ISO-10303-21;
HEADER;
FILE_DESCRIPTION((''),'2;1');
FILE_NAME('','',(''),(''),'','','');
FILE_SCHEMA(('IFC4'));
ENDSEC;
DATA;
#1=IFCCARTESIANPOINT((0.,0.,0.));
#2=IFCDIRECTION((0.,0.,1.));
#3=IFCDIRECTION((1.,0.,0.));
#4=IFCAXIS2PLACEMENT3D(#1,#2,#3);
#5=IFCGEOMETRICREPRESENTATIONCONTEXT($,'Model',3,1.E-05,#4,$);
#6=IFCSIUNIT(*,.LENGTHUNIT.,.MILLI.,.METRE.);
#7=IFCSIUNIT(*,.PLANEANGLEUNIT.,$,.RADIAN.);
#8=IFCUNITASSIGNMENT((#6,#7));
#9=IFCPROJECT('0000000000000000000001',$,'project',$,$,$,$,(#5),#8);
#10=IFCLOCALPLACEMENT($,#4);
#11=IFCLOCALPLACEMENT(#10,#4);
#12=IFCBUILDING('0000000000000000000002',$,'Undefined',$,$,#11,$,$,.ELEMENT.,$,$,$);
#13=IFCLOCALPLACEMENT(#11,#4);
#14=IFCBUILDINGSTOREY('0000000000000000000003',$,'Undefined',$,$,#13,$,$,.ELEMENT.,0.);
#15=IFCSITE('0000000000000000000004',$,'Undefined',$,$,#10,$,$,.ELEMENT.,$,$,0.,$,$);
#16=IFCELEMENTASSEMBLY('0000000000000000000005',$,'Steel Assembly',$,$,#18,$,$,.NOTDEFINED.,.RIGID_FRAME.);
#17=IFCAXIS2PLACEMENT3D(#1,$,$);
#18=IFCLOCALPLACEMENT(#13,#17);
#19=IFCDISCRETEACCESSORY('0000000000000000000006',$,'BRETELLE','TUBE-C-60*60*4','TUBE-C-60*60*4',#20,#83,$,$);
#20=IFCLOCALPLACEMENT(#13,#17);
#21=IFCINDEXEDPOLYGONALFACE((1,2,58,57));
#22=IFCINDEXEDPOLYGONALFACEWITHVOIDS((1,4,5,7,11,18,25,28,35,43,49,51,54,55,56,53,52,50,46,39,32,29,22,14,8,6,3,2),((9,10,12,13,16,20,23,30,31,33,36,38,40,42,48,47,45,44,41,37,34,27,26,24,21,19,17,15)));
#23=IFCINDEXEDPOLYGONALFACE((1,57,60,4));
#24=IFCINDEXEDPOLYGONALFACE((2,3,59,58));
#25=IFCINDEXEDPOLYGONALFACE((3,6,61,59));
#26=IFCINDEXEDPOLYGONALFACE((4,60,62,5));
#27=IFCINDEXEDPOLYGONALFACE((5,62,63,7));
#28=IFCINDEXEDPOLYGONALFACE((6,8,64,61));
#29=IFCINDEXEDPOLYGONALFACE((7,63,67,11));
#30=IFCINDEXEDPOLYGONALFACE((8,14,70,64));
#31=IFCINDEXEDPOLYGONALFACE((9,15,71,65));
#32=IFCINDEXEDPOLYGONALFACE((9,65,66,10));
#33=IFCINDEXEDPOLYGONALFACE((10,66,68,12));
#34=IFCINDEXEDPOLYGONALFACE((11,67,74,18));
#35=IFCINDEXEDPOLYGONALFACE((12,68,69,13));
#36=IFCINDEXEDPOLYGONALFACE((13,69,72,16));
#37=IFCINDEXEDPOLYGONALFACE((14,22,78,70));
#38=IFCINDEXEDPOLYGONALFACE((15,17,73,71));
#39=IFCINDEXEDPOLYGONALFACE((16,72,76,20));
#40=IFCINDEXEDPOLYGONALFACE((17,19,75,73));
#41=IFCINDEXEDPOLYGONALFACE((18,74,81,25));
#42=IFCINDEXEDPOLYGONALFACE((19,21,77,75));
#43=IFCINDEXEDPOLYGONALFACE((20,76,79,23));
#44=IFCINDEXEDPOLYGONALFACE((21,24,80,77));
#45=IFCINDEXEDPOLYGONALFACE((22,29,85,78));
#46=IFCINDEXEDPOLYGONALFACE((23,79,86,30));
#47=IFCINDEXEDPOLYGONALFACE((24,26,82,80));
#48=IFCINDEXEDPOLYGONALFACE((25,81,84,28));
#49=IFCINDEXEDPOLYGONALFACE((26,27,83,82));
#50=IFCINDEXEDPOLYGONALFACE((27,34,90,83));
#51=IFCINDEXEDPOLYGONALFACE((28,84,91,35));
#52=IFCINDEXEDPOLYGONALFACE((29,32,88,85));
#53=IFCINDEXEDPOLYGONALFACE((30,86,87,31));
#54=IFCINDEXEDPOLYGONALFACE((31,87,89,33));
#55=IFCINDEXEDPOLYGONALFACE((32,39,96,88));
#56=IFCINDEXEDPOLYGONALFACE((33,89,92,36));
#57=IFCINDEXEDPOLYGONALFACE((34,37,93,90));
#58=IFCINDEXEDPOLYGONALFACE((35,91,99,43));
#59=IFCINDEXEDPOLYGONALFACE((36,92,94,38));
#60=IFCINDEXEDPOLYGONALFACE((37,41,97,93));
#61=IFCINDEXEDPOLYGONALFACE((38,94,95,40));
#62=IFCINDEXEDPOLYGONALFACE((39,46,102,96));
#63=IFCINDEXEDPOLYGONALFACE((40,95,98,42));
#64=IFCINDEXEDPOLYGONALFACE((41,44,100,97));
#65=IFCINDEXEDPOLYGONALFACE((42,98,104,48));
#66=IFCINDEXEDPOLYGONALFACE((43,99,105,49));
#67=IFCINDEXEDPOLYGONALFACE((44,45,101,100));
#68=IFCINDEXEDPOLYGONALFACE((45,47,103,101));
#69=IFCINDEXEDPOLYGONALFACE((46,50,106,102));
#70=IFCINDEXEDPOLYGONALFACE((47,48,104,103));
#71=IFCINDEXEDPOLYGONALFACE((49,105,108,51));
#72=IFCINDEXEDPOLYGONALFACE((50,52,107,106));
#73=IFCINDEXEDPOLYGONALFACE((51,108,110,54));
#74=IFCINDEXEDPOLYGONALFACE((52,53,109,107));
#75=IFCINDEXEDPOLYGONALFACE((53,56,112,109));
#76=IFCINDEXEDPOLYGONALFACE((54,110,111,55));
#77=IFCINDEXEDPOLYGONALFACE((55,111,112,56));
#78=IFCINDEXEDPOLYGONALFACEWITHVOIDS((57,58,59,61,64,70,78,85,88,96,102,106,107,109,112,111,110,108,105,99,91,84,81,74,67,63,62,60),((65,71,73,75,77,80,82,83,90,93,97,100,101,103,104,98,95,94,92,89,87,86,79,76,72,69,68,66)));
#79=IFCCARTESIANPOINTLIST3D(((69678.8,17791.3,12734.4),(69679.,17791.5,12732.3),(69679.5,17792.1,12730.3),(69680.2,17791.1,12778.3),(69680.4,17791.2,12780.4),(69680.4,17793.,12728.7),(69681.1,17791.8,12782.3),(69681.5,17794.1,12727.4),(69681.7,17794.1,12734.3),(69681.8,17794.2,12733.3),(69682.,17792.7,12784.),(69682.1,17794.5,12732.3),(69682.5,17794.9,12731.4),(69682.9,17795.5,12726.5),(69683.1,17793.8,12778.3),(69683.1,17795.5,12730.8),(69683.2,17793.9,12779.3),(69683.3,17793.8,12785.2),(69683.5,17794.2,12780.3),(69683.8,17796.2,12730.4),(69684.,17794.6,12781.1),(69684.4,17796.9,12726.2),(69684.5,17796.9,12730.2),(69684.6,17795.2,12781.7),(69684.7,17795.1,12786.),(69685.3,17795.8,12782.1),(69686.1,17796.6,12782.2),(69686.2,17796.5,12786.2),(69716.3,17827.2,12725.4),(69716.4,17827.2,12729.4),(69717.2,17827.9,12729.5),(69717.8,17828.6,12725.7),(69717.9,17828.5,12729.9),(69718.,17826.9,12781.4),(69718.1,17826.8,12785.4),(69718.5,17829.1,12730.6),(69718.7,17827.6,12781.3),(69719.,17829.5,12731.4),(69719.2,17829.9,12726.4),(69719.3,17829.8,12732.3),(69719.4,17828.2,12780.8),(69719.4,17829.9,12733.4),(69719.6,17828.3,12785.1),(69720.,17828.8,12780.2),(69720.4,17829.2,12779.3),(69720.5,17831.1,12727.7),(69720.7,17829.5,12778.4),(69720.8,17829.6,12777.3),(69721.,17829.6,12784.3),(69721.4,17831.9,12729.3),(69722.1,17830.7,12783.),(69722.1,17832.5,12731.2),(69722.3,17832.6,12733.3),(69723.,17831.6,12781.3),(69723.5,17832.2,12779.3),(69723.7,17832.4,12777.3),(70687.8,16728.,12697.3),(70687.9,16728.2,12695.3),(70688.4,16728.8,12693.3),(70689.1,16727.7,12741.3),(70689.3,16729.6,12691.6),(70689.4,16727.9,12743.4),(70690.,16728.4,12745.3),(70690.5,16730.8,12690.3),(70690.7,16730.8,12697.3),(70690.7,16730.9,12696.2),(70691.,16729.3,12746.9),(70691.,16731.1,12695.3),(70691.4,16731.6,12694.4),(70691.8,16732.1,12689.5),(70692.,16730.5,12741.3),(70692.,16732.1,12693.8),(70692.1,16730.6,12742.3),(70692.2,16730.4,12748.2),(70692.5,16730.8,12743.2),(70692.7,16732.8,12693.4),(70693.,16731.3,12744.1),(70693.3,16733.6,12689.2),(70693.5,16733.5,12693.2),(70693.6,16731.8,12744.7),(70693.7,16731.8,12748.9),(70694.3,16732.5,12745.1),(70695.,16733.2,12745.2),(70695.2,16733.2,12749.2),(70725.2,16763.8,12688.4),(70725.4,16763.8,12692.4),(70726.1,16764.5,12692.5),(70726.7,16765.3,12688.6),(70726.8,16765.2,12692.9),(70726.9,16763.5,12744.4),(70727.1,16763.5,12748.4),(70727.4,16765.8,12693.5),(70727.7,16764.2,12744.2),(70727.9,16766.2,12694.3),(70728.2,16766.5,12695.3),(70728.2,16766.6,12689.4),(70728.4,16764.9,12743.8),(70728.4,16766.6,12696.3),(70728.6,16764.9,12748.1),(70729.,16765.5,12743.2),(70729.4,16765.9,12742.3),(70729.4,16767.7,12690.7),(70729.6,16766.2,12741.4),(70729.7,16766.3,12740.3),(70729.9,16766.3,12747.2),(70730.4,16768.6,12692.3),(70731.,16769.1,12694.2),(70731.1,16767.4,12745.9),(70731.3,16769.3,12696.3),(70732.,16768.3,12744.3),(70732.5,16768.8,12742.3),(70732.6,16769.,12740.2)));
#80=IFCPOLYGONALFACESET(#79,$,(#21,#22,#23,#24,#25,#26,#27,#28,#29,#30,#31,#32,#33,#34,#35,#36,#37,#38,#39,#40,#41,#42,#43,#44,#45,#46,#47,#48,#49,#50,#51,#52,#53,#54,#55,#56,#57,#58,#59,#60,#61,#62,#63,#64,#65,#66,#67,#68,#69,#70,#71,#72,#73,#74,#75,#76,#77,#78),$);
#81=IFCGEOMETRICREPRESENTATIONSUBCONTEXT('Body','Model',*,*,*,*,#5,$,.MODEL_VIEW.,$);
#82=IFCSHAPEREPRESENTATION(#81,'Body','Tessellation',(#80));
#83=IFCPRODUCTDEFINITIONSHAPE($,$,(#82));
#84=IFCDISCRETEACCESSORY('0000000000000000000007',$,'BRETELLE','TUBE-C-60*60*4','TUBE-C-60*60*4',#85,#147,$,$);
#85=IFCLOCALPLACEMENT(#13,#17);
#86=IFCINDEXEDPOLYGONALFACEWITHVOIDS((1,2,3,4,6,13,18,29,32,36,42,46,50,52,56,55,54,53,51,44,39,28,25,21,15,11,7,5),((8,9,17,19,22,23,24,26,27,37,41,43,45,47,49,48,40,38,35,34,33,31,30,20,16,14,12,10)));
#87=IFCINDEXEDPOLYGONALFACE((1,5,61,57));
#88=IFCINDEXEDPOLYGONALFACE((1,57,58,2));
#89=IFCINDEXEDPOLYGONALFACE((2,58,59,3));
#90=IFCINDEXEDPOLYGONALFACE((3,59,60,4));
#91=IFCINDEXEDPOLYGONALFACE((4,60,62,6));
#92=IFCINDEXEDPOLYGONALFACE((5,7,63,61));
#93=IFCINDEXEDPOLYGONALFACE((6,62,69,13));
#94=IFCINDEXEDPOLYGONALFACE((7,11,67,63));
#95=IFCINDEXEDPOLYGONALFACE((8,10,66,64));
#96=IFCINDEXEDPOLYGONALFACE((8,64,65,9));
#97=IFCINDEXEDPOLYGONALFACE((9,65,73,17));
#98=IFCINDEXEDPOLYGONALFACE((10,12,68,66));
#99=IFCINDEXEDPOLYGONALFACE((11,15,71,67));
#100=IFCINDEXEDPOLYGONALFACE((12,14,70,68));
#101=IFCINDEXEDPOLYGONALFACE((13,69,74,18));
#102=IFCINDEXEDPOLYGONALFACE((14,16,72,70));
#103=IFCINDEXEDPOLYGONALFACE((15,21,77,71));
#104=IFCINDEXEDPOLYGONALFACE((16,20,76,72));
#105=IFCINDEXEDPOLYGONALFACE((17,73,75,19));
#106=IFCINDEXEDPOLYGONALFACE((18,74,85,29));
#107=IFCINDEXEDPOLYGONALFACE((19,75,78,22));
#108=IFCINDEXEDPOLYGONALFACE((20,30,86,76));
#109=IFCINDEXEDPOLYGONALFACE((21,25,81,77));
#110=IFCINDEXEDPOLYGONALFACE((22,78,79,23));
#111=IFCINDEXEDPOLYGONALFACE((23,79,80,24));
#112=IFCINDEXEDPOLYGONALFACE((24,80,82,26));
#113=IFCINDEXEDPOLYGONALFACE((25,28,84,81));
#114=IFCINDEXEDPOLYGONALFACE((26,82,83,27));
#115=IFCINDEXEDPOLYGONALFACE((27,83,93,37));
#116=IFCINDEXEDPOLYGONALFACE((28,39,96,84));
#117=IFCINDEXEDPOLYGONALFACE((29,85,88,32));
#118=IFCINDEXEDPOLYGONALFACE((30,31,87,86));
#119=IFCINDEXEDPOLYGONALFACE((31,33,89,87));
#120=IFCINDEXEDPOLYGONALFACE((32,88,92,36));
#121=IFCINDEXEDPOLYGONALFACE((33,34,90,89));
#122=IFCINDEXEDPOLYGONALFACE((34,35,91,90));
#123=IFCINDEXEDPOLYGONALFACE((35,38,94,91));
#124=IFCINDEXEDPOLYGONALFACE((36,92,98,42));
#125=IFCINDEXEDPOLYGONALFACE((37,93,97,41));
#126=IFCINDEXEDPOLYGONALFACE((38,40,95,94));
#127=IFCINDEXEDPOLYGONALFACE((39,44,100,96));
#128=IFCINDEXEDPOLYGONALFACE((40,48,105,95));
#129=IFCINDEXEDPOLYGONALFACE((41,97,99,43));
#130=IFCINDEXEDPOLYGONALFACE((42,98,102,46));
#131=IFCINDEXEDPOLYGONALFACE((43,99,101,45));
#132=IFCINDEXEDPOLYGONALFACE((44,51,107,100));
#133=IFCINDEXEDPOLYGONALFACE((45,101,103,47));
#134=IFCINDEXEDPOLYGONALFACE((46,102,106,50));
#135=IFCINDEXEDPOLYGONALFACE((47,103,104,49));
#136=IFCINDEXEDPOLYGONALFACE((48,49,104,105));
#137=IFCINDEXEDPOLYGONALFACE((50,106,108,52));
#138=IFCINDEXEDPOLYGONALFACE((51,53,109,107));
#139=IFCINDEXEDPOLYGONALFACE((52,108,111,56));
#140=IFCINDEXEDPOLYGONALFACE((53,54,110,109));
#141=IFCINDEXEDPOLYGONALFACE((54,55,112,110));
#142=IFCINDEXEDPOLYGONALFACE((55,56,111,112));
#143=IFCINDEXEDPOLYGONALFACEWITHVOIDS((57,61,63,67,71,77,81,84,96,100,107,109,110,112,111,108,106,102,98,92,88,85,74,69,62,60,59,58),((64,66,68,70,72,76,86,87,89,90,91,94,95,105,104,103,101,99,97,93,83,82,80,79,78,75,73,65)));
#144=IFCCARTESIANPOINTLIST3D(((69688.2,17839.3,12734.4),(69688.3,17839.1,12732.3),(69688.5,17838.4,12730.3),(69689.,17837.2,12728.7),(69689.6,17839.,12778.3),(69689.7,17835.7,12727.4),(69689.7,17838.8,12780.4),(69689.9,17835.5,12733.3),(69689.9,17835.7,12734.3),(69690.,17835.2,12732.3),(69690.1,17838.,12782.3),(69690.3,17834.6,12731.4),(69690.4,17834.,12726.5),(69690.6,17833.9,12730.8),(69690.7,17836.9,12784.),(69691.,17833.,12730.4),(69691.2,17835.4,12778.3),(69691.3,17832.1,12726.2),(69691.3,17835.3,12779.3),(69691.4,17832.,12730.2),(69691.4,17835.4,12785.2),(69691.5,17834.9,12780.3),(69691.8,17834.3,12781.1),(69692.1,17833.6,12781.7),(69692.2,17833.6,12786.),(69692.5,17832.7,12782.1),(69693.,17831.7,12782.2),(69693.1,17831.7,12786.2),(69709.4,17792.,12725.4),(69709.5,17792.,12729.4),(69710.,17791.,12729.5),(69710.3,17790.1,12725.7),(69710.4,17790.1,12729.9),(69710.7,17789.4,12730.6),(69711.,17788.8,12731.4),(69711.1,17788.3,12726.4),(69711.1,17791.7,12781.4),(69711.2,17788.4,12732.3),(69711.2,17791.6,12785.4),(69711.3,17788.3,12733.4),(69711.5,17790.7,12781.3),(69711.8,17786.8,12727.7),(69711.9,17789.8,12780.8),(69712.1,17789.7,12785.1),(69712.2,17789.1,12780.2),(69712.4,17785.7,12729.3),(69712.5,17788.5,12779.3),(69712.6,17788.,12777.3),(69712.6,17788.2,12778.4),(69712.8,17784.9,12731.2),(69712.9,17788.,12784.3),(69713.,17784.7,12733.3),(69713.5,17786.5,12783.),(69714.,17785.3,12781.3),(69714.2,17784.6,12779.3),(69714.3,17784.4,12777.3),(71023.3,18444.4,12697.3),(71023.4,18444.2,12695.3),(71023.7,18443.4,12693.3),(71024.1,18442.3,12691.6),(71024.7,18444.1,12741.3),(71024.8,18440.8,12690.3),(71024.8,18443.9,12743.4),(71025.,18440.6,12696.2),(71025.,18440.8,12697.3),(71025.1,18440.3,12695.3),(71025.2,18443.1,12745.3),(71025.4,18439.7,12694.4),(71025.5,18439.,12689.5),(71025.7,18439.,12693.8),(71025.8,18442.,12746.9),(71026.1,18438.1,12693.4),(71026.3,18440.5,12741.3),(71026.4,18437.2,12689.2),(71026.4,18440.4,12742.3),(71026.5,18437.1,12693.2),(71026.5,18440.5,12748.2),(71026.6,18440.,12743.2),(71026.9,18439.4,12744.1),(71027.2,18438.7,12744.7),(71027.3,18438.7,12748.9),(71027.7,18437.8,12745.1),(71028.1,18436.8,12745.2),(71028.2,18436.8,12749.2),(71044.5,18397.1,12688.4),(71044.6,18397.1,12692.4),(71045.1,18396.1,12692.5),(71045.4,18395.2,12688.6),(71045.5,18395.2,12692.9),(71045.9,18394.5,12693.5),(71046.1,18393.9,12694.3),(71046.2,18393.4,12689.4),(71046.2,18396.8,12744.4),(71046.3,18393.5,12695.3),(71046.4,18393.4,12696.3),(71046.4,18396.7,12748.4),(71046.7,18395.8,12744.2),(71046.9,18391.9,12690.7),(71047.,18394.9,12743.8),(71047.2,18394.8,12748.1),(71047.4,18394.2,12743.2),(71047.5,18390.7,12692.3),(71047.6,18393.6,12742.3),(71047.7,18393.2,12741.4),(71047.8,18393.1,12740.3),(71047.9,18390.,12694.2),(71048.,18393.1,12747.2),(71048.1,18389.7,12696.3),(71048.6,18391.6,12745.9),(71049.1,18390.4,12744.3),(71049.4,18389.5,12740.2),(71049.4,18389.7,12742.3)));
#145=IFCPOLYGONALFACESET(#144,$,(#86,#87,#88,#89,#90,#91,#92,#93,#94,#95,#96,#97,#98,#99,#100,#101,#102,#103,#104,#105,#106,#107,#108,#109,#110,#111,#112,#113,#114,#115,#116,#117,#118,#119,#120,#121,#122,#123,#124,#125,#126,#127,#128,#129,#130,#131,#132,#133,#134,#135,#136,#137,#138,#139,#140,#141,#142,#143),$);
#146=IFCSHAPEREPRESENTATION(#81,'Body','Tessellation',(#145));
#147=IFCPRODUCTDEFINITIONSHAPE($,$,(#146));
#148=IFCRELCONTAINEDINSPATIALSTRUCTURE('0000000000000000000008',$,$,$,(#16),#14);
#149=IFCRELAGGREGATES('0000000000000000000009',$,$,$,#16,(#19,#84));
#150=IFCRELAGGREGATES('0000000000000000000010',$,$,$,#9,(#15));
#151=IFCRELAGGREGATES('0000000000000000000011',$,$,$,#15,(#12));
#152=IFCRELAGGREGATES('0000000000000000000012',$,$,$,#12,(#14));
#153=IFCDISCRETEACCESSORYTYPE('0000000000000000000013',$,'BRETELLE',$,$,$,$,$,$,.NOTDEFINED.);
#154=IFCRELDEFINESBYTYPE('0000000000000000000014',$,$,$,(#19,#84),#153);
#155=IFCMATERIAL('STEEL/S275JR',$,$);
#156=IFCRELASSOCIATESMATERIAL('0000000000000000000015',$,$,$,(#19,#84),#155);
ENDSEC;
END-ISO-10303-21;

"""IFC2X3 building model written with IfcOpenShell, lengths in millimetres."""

from ifc_helpers import new_model, si_unit, frame, origin_with_axes, origin_2d_with_axis, place, context, subcontext, project, spatial, hollow_rectangle, extrude, material, type_object, element, aggregate, save


model = new_model("IFC2X3")

# Units and contexts
model_context = context("Model", 3, precision=1e-05, world=origin_with_axes())
body_context = subcontext(model_context, "Body", "Model", "MODEL_VIEW")
ifc_project = project(units=[si_unit("LENGTHUNIT", "METRE", prefix="MILLI"), si_unit("PLANEANGLEUNIT", "RADIAN")], contexts=[model_context])

# Site, building, storey
site_placement = place(None, origin_with_axes())
site = spatial("IfcSite", under=ifc_project, at=site_placement, Name="Undefined", CompositionType="ELEMENT", RefElevation=0.0)
building_placement = place(site_placement, origin_with_axes())
building = spatial("IfcBuilding", under=site, at=building_placement, Name="Undefined", CompositionType="ELEMENT")
storey_placement = place(building_placement, origin_with_axes())
storey = spatial("IfcBuildingStorey", under=building, at=storey_placement, Name="Undefined", CompositionType="ELEMENT", Elevation=0.0)

# Shared definitions
ifc_material = material(Name="STEEL/S275JR")

# Element assembly, discrete accessories
assembly_1_placement = place(storey_placement, origin_with_axes())
assembly_1 = element("IfcElementAssembly", 1, at=assembly_1_placement, inside=storey, Name="Steel Assembly", AssemblyPlace="NOTDEFINED", PredefinedType="RIGID_FRAME")
discrete_accessory_type_1 = type_object("IfcDiscreteAccessoryType", Name="BRETELLE")
discrete_accessory_1_placement = place(assembly_1_placement, frame((69701.3, 17811.9, 12755.8), z_axis=(0.724985, 0.68853, -0.017961), x_axis=(0.688093, -0.725184, -0.025247)))
discrete_accessory_1 = element("IfcDiscreteAccessory", 2, at=discrete_accessory_1_placement, type_object=discrete_accessory_type_1, material=ifc_material, Name="BRETELLE", Description="TUBE-C-60*60*4", ObjectType="TUBE-C-60*60*4", context=body_context, shape_type="SweptSolid", body=[
    extrude(hollow_rectangle(XDim=60.0, YDim=60.0, WallThickness=4.0, InnerFilletRadius=4.0, OuterFilletRadius=8.0, at=origin_2d_with_axis()), frame((1466.3, 0.0, 0.0), z_axis=(-1.0, 0.0, 0.0), x_axis=(0.0, -1.0, 0.0)), (0.0, 0.0, 1.0), 1466.3),
])
discrete_accessory_2_placement = place(assembly_1_placement, frame((71036.4, 18416.9, 12718.8), z_axis=(-0.412318, 0.910863, 0.017961), x_axis=(-0.910532, -0.412666, 0.025247)))
discrete_accessory_2 = element("IfcDiscreteAccessory", 3, at=discrete_accessory_2_placement, type_object=discrete_accessory_type_1, material=ifc_material, Name="BRETELLE", Description="TUBE-C-60*60*4", ObjectType="TUBE-C-60*60*4", context=body_context, shape_type="SweptSolid", body=[
    extrude(hollow_rectangle(XDim=60.0, YDim=60.0, WallThickness=4.0, InnerFilletRadius=4.0, OuterFilletRadius=8.0, at=origin_2d_with_axis()), frame((1466.3, 0.0, 0.0), z_axis=(-1.0, 0.0, 0.0), x_axis=(0.0, -1.0, 0.0)), (0.0, 0.0, 1.0), 1466.3),
])
aggregate(assembly_1, [discrete_accessory_1, discrete_accessory_2])

save(model, "model.ifc")
